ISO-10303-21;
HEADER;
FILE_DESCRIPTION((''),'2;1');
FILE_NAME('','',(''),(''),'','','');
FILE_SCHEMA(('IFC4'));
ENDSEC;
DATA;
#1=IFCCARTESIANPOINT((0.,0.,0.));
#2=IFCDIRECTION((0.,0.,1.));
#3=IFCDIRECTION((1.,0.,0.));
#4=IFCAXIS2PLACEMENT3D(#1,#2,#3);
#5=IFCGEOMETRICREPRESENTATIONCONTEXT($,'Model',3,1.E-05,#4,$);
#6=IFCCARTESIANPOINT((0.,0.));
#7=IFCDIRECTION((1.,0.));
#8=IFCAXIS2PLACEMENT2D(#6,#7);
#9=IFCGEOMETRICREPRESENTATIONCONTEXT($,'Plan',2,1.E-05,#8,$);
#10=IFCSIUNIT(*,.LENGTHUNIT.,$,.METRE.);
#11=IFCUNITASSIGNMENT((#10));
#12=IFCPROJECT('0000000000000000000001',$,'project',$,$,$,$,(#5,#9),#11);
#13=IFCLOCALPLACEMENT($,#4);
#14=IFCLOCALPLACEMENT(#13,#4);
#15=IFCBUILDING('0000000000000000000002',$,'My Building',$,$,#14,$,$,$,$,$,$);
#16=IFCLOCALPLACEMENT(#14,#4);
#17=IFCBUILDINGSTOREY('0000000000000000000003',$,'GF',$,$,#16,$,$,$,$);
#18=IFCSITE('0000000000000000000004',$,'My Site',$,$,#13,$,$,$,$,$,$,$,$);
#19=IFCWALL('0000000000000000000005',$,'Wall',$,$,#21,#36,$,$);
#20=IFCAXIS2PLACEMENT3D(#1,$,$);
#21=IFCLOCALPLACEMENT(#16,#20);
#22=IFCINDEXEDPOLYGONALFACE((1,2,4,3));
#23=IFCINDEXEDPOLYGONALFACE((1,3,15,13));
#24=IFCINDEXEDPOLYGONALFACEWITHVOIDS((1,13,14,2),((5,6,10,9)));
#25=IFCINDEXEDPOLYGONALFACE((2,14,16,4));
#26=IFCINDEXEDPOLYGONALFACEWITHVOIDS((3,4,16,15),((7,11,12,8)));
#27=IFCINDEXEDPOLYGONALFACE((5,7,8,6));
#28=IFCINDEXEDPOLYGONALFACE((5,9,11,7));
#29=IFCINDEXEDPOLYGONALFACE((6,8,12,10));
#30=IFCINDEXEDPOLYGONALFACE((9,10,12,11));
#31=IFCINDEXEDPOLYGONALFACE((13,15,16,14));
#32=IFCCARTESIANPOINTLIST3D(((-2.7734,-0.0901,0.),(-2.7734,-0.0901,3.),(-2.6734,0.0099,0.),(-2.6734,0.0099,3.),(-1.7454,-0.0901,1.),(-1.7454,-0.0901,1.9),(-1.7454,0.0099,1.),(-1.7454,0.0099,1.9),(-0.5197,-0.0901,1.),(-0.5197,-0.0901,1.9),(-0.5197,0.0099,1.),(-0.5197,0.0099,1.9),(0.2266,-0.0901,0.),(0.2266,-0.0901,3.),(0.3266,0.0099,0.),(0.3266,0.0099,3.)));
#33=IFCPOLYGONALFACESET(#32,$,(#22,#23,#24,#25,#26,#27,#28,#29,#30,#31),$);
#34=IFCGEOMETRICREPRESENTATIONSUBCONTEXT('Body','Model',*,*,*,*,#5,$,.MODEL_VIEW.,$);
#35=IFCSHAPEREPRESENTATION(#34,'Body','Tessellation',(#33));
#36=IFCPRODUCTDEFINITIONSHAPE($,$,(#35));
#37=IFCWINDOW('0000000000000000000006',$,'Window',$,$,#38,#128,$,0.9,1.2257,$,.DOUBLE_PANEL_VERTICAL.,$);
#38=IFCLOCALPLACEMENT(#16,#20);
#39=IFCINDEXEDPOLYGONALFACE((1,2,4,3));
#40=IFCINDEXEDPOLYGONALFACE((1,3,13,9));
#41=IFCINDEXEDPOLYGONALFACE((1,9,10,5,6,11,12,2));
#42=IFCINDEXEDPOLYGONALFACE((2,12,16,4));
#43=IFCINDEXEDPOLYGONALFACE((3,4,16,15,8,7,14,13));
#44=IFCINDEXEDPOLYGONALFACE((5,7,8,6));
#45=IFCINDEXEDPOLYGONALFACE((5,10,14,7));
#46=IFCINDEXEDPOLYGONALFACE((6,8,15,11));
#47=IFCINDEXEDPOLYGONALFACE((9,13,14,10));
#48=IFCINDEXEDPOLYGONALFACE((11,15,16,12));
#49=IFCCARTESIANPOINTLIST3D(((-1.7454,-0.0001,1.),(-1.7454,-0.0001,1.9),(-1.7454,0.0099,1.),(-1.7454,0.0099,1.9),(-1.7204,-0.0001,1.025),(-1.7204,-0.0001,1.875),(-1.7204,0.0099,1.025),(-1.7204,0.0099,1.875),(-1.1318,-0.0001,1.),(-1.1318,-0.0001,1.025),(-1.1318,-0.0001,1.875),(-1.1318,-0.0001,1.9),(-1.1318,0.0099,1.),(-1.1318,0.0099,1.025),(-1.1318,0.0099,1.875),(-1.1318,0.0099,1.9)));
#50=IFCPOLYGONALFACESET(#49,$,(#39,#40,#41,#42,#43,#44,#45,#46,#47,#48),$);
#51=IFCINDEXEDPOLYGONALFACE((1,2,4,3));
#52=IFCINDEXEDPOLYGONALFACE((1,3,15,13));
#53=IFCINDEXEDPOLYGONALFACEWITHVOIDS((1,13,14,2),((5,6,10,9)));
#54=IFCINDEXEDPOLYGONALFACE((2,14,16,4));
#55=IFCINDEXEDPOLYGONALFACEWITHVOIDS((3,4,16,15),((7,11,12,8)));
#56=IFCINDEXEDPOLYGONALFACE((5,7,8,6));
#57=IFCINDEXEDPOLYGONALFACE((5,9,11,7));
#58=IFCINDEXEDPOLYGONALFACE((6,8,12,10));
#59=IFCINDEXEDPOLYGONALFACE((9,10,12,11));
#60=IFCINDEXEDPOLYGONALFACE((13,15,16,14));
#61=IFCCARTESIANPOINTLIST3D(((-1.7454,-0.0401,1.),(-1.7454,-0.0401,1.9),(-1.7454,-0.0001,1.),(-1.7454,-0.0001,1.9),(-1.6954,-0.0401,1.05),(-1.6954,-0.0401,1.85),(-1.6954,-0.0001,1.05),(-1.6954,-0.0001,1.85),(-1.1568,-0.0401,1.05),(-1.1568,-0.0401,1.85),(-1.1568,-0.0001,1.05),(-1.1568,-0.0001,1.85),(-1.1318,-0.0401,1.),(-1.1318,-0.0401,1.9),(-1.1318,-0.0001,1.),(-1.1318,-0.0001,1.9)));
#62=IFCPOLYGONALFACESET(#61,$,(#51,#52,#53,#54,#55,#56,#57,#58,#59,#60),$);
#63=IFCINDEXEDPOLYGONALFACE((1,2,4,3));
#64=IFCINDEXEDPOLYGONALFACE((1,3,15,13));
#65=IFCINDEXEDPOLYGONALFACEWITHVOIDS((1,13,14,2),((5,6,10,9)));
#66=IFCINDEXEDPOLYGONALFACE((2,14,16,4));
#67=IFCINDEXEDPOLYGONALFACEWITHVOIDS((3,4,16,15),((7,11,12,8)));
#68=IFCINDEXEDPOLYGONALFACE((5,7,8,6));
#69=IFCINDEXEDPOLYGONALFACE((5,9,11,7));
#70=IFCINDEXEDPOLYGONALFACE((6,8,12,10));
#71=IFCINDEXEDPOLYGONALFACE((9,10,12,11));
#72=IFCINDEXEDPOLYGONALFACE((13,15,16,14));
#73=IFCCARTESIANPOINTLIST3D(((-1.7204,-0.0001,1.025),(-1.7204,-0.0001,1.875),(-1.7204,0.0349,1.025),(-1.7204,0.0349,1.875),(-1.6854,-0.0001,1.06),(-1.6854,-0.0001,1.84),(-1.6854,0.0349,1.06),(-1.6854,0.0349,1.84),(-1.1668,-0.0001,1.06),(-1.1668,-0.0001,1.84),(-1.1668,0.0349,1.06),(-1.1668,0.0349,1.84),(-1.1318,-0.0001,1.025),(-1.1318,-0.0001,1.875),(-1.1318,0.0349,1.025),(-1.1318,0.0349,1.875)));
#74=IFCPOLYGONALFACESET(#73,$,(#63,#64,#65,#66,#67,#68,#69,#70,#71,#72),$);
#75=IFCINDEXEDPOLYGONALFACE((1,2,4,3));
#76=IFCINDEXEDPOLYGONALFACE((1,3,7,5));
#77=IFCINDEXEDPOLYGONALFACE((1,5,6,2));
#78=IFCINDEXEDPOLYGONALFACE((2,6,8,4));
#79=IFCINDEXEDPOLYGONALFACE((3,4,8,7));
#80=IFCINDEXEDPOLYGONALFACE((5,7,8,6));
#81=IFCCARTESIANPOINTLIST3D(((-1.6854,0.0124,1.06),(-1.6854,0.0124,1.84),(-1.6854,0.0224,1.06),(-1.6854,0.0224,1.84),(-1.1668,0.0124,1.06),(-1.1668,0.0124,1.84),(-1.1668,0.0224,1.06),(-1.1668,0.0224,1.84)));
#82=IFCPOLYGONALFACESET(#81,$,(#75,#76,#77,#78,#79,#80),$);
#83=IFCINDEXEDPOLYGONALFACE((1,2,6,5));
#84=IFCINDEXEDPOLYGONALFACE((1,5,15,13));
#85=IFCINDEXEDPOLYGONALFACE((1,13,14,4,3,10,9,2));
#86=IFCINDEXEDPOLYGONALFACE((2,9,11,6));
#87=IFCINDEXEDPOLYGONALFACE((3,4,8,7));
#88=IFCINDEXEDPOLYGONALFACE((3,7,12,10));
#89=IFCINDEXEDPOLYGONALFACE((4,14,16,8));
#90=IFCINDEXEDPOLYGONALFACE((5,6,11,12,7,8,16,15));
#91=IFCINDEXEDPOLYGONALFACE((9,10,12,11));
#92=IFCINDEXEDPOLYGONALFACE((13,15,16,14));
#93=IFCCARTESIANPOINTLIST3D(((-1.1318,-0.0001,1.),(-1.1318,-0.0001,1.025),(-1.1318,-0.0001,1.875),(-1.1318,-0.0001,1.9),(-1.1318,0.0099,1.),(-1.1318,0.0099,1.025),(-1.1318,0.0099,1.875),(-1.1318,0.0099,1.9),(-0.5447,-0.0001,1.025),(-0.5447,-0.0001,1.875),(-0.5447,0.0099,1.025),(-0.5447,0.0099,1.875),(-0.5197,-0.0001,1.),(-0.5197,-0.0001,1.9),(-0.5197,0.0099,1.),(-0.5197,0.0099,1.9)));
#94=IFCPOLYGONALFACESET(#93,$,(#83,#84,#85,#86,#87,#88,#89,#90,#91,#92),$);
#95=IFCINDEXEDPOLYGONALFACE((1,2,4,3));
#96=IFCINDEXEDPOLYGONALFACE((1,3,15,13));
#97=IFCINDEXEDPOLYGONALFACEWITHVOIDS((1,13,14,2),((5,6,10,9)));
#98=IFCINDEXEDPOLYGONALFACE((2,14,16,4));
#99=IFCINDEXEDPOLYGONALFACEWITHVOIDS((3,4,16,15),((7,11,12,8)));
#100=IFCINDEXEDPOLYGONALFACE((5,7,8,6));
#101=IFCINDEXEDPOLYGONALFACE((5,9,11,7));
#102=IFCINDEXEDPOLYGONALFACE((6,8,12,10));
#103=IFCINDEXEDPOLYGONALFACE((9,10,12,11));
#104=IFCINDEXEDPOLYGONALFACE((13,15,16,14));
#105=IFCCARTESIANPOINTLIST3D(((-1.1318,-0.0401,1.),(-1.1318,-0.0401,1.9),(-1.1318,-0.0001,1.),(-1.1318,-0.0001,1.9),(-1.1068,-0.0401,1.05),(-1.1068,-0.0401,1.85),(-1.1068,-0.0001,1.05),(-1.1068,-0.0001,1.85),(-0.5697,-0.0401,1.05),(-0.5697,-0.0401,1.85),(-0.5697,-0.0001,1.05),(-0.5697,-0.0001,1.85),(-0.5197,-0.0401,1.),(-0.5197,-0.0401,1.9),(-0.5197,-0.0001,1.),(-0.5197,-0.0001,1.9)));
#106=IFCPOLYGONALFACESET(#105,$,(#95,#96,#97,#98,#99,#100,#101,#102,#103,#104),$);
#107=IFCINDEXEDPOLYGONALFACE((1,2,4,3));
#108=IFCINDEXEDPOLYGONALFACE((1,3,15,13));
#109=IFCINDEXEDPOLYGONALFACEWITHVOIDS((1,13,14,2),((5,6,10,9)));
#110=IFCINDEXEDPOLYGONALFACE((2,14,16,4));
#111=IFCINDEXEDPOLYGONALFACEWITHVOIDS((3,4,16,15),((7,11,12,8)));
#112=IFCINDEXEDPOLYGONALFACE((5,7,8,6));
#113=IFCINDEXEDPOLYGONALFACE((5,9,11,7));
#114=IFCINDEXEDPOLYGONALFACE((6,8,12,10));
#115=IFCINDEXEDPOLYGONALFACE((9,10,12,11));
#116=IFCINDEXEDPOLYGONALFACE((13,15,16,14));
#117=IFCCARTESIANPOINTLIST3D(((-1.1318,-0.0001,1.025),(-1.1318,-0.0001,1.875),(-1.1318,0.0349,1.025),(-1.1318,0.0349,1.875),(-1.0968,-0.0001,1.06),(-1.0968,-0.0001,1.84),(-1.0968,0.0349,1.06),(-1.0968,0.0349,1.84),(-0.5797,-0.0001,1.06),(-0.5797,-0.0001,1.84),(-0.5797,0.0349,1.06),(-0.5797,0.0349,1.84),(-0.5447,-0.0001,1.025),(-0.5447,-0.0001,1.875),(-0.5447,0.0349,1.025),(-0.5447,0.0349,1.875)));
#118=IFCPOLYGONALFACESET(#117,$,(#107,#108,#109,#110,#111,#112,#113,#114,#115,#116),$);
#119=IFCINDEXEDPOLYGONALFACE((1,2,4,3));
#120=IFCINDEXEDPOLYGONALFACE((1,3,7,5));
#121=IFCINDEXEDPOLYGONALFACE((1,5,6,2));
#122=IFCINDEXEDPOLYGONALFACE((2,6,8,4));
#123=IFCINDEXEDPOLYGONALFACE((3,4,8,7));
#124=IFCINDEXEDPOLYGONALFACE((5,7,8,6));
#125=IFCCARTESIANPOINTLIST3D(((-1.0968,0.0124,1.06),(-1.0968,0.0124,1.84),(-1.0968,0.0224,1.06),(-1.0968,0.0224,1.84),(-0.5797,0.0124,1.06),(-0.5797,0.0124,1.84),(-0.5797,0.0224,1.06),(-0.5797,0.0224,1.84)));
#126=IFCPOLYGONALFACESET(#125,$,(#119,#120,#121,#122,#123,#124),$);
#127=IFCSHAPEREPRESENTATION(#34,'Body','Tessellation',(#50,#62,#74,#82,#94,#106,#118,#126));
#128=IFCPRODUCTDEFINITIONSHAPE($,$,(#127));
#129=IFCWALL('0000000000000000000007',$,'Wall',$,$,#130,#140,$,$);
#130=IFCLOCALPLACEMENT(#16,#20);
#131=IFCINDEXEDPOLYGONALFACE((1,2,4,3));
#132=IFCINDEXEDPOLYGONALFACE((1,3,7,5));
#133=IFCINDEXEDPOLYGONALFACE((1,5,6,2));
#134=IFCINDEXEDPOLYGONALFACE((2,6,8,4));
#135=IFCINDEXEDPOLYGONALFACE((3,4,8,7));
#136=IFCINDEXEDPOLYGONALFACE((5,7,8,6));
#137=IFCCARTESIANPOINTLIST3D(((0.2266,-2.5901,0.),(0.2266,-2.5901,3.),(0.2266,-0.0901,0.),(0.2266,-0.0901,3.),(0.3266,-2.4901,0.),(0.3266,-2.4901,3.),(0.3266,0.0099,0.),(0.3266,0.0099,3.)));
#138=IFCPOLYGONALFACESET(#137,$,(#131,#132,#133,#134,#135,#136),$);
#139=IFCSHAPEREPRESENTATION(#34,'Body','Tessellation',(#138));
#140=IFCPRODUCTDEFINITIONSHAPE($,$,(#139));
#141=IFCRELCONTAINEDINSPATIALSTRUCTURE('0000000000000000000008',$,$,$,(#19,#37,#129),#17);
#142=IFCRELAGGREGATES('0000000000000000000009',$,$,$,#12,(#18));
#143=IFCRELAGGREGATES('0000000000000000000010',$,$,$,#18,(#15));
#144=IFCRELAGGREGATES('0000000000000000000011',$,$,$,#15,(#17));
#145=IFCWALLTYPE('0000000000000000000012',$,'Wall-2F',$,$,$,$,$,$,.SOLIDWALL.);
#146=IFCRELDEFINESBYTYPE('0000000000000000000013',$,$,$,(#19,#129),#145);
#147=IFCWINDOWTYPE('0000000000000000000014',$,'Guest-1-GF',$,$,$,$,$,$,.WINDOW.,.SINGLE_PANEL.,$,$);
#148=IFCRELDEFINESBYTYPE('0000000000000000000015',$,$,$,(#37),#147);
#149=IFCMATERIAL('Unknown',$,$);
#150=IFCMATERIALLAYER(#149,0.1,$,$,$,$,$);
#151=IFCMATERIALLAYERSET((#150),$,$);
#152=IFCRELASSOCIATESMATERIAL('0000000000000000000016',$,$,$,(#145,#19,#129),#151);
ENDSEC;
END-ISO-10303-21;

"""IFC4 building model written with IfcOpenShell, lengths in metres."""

from ifc_helpers import new_model, entity, si_unit, frame, origin_with_axes, origin_2d_with_axis, place, context, subcontext, project, spatial, line, indexed_curve, outline, extrude, shape, source, transform, mapped, material, layer, layer_set, layer_usage, type_object, type_shapes, element, fill, save


model = new_model("IFC4")

# Units and contexts
model_context = context("Model", 3, precision=1e-05, world=origin_with_axes())
plan_context = context("Plan", 2, precision=1e-05, world=origin_2d_with_axis())
body_context_1 = subcontext(model_context, "Body", "Model", "MODEL_VIEW")
body_context_2 = subcontext(plan_context, "Body", "Plan", "PLAN_VIEW")
ifc_project = project(units=[si_unit("LENGTHUNIT", "METRE")], contexts=[model_context, plan_context])

# Site, building, storey
site_placement = place(None, origin_with_axes())
site = spatial("IfcSite", under=ifc_project, at=site_placement, Name="My Site")
building_placement = place(site_placement, origin_with_axes())
building = spatial("IfcBuilding", under=site, at=building_placement, Name="My Building")
storey_placement = place(building_placement, origin_with_axes())
storey = spatial("IfcBuildingStorey", under=building, at=storey_placement, Name="GF")

# Shared definitions
ifc_material_1 = material(Name="Unknown")

# Shared definitions
ifc_layer_1 = layer(ifc_material_1, 0.1)
ifc_layer_set_1 = layer_set([ifc_layer_1])
wall_type = type_object("IfcWallType", Name="Wall-2F", PredefinedType="SOLIDWALL", material=ifc_layer_set_1)

# Wall, opening, window
ifc_layer_usage_1 = layer_usage(ifc_layer_set_1, "AXIS2", "POSITIVE", 0.0)
wall_1_placement = place(storey_placement, frame((-2.7734, -0.0901, 0.0), z_axis=(0.0, 0.0, 1.0), x_axis=(1.0, 0.0, 0.0)))
wall_1 = element("IfcWall", 1, at=wall_1_placement, inside=storey, type_object=wall_type, material=ifc_layer_usage_1, Name="Wall", context=body_context_1, shape_type="SweptSolid", body=[
    extrude(outline(indexed_curve([(0.0, 0.0), (0.1, 0.1), (3.1, 0.1), (3.0, 0.0)], segments=[line(1, 2, 3, 4, 1)])), origin_with_axes(), (0.0, 0.0, 1.0), 3.0),
])
shared_shape_1 = source(origin_with_axes(), body_context_1, "Body", "SweptSolid", [
    extrude(outline(indexed_curve([(0.0, 0.0), (1.2257, 0.0), (1.2257, 0.9), (0.0, 0.9)], segments=[line(1, 2, 3, 4, 1)])), frame((0.0, -0.6, 0.0), z_axis=(0.0, -1.0, 0.0), x_axis=(1.0, 0.0, 0.0)), (0.0, 0.0, -1.0), 1.2),
])
opening_1_placement = place(wall_1_placement, frame((1.028, 0.0, 1.0), z_axis=(0.0, 0.0, 1.0), x_axis=(1.0, -0.000001, 0.0)))
opening_1 = element("IfcOpeningElement", 2, at=opening_1_placement, cuts=wall_1, PredefinedType="OPENING", context=body_context_1, shape_type="MappedRepresentation", body=[
    mapped(shared_shape_1, transform((0.0, 0.0, 0.0), x_axis=(1.0, 0.0, 0.0), y_axis=(0.0, 1.0, 0.0), z_axis=(0.0, 0.0, 1.0), scale=1.0)),
])
window_type_1 = type_object("IfcWindowType", Name="Guest-1-GF", PartitioningType="SINGLE_PANEL", PredefinedType="WINDOW")
shared_shape_2 = source(origin_with_axes(), body_context_1, "Body", "SweptSolid", [
    extrude(outline(indexed_curve([(0.6136, 0.0), (0.0, 0.0), (0.0, 0.9), (0.6136, 0.9), (0.6136, 0.875), (0.025, 0.875), (0.025, 0.025), (0.6136, 0.025)], segments=[line(1, 2, 3, 4, 5, 6, 7, 8, 1)])), frame((0.0, 0.09, 0.0), z_axis=(0.0, -1.0, 0.0), x_axis=(1.0, 0.0, 0.0)), (0.0, 0.0, -1.0), 0.01),
    extrude(outline(indexed_curve([(0.0, 0.0), (0.6136, 0.0), (0.6136, 0.9), (0.0, 0.9)], segments=[line(1, 2, 3, 4, 1)]), holes=[indexed_curve([(0.05, 0.05), (0.5886, 0.05), (0.5886, 0.85), (0.05, 0.85)], segments=[line(1, 2, 3, 4, 1)])]), frame((0.0, 0.05, 0.0), z_axis=(0.0, -1.0, 0.0), x_axis=(1.0, 0.0, 0.0)), (0.0, 0.0, -1.0), 0.04),
    extrude(outline(indexed_curve([(0.0, 0.0), (0.5886, 0.0), (0.5886, 0.85), (0.0, 0.85)], segments=[line(1, 2, 3, 4, 1)]), holes=[indexed_curve([(0.035, 0.035), (0.5536, 0.035), (0.5536, 0.815), (0.035, 0.815)], segments=[line(1, 2, 3, 4, 1)])]), frame((0.025, 0.09, 0.025), z_axis=(0.0, -1.0, 0.0), x_axis=(1.0, 0.0, 0.0)), (0.0, 0.0, -1.0), 0.035),
    extrude(outline(indexed_curve([(0.035, 0.035), (0.5536, 0.035), (0.5536, 0.815), (0.035, 0.815)], segments=[line(1, 2, 3, 4, 1)])), frame((0.025, 0.1025, 0.025), z_axis=(0.0, -1.0, 0.0), x_axis=(1.0, 0.0, 0.0)), (0.0, 0.0, -1.0), 0.01),
    extrude(outline(indexed_curve([(0.0, 0.9), (0.6121, 0.9), (0.6121, 0.0), (0.0, 0.0), (0.0, 0.025), (0.5871, 0.025), (0.5871, 0.875), (0.0, 0.875)], segments=[line(1, 2, 3, 4, 5, 6, 7, 8, 1)])), frame((0.6136, 0.09, 0.0), z_axis=(0.0, -1.0, 0.0), x_axis=(1.0, 0.0, 0.0)), (0.0, 0.0, -1.0), 0.01),
    extrude(outline(indexed_curve([(0.0, 0.0), (0.6121, 0.0), (0.6121, 0.9), (0.0, 0.9)], segments=[line(1, 2, 3, 4, 1)]), holes=[indexed_curve([(0.025, 0.05), (0.5621, 0.05), (0.5621, 0.85), (0.025, 0.85)], segments=[line(1, 2, 3, 4, 1)])]), frame((0.6136, 0.05, 0.0), z_axis=(0.0, -1.0, 0.0), x_axis=(1.0, 0.0, 0.0)), (0.0, 0.0, -1.0), 0.04),
    extrude(outline(indexed_curve([(0.0, 0.0), (0.5871, 0.0), (0.5871, 0.85), (0.0, 0.85)], segments=[line(1, 2, 3, 4, 1)]), holes=[indexed_curve([(0.035, 0.035), (0.5521, 0.035), (0.5521, 0.815), (0.035, 0.815)], segments=[line(1, 2, 3, 4, 1)])]), frame((0.6136, 0.09, 0.025), z_axis=(0.0, -1.0, 0.0), x_axis=(1.0, 0.0, 0.0)), (0.0, 0.0, -1.0), 0.035),
    extrude(outline(indexed_curve([(0.035, 0.035), (0.5521, 0.035), (0.5521, 0.815), (0.035, 0.815)], segments=[line(1, 2, 3, 4, 1)])), frame((0.6136, 0.1025, 0.025), z_axis=(0.0, -1.0, 0.0), x_axis=(1.0, 0.0, 0.0)), (0.0, 0.0, -1.0), 0.01),
])
shared_shape_3 = source(origin_with_axes(), body_context_2, "Body", "Curve2D", [
    entity("IfcIndexedPolyCurve", entity("IfcCartesianPointList2D", [[0.05, 0.05], [0.5886, 0.05]])),
    entity("IfcIndexedPolyCurve", entity("IfcCartesianPointList2D", [[0.0, 0.1], [0.025, 0.1], [0.025, 0.09], [0.05, 0.09], [0.05, 0.05], [0.0, 0.05]]), [entity("IfcLineIndex", [1, 2, 3, 4, 5, 6, 1])]),
    entity("IfcIndexedPolyCurve", entity("IfcCartesianPointList2D", [[0.6136, 0.1], [0.6136, 0.1], [0.6136, 0.09], [0.5886, 0.09], [0.5886, 0.05], [0.6136, 0.05]])),
    entity("IfcIndexedPolyCurve", entity("IfcCartesianPointList2D", [[0.025, 0.09], [0.06, 0.09], [0.06, 0.125], [0.025, 0.125]]), [entity("IfcLineIndex", [1, 2, 3, 4, 1])]),
    entity("IfcIndexedPolyCurve", entity("IfcCartesianPointList2D", [[0.6136, 0.09], [0.5786, 0.09], [0.5786, 0.125], [0.6136, 0.125]]), [entity("IfcLineIndex", [1, 2, 3, 4, 1])]),
    entity("IfcIndexedPolyCurve", entity("IfcCartesianPointList2D", [[0.06, 0.09], [0.5786, 0.09]])),
    entity("IfcIndexedPolyCurve", entity("IfcCartesianPointList2D", [[0.06, 0.125], [0.5786, 0.125]])),
    entity("IfcIndexedPolyCurve", entity("IfcCartesianPointList2D", [[0.06, 0.1075], [0.5786, 0.1075]])),
    entity("IfcIndexedPolyCurve", entity("IfcCartesianPointList2D", [[0.6386, 0.05], [1.1757, 0.05]])),
    entity("IfcIndexedPolyCurve", entity("IfcCartesianPointList2D", [[0.6136, 0.1], [0.6136, 0.1], [0.6136, 0.09], [0.6386, 0.09], [0.6386, 0.05], [0.6136, 0.05]])),
    entity("IfcIndexedPolyCurve", entity("IfcCartesianPointList2D", [[1.2257, 0.1], [1.2007, 0.1], [1.2007, 0.09], [1.1757, 0.09], [1.1757, 0.05], [1.2257, 0.05]]), [entity("IfcLineIndex", [1, 2, 3, 4, 5, 6, 1])]),
    entity("IfcIndexedPolyCurve", entity("IfcCartesianPointList2D", [[0.6136, 0.09], [0.6486, 0.09], [0.6486, 0.125], [0.6136, 0.125]]), [entity("IfcLineIndex", [1, 2, 3, 4, 1])]),
    entity("IfcIndexedPolyCurve", entity("IfcCartesianPointList2D", [[1.2007, 0.09], [1.1657, 0.09], [1.1657, 0.125], [1.2007, 0.125]]), [entity("IfcLineIndex", [1, 2, 3, 4, 1])]),
    entity("IfcIndexedPolyCurve", entity("IfcCartesianPointList2D", [[0.6486, 0.09], [1.1657, 0.09]])),
    entity("IfcIndexedPolyCurve", entity("IfcCartesianPointList2D", [[0.6486, 0.125], [1.1657, 0.125]])),
    entity("IfcIndexedPolyCurve", entity("IfcCartesianPointList2D", [[0.6486, 0.1075], [1.1657, 0.1075]])),
])
type_shapes(window_type_1, [shared_shape_2, shared_shape_3])
window_1_placement = place(opening_1_placement, frame((0.0, 0.0, 0.0), z_axis=(0.0, 0.0, 1.0), x_axis=(1.0, 0.0, 0.0)))
window_1 = element("IfcWindow", 3, at=window_1_placement, inside=storey, type_object=window_type_1, Name="Window", OverallHeight=0.9, OverallWidth=1.2257, PartitioningType="DOUBLE_PANEL_VERTICAL", shapes=[
    shape(body_context_1, "Body", "MappedRepresentation", [mapped(shared_shape_2, transform((0.0, 0.0, 0.0), x_axis=(1.0, 0.0, 0.0), y_axis=(0.0, 1.0, 0.0), z_axis=(0.0, 0.0, 1.0), scale=1.0))]),
    shape(body_context_2, "Body", "MappedRepresentation", [mapped(shared_shape_3, transform((0.0, 0.0, 0.0), x_axis=(1.0, 0.0, 0.0), y_axis=(0.0, 1.0, 0.0), z_axis=(0.0, 0.0, 1.0), scale=1.0))]),
])
fill(opening_1, window_1)

# Wall
ifc_layer_usage_2 = layer_usage(ifc_layer_set_1, "AXIS2", "POSITIVE", 0.0)
wall_2_placement = place(storey_placement, frame((0.2266, -0.0901, 0.0), z_axis=(0.0, 0.0, 1.0), x_axis=(0.0, -1.0, 0.0)))
element("IfcWall", 4, at=wall_2_placement, inside=storey, type_object=wall_type, material=ifc_layer_usage_2, Name="Wall", context=body_context_1, shape_type="SweptSolid", body=[
    extrude(outline(indexed_curve([(0.0, 0.0), (-0.1, 0.1), (2.4, 0.1), (2.5, 0.0)], segments=[line(1, 2, 3, 4, 1)])), origin_with_axes(), (0.0, 0.0, 1.0), 3.0),
])

save(model, "model.ifc")
